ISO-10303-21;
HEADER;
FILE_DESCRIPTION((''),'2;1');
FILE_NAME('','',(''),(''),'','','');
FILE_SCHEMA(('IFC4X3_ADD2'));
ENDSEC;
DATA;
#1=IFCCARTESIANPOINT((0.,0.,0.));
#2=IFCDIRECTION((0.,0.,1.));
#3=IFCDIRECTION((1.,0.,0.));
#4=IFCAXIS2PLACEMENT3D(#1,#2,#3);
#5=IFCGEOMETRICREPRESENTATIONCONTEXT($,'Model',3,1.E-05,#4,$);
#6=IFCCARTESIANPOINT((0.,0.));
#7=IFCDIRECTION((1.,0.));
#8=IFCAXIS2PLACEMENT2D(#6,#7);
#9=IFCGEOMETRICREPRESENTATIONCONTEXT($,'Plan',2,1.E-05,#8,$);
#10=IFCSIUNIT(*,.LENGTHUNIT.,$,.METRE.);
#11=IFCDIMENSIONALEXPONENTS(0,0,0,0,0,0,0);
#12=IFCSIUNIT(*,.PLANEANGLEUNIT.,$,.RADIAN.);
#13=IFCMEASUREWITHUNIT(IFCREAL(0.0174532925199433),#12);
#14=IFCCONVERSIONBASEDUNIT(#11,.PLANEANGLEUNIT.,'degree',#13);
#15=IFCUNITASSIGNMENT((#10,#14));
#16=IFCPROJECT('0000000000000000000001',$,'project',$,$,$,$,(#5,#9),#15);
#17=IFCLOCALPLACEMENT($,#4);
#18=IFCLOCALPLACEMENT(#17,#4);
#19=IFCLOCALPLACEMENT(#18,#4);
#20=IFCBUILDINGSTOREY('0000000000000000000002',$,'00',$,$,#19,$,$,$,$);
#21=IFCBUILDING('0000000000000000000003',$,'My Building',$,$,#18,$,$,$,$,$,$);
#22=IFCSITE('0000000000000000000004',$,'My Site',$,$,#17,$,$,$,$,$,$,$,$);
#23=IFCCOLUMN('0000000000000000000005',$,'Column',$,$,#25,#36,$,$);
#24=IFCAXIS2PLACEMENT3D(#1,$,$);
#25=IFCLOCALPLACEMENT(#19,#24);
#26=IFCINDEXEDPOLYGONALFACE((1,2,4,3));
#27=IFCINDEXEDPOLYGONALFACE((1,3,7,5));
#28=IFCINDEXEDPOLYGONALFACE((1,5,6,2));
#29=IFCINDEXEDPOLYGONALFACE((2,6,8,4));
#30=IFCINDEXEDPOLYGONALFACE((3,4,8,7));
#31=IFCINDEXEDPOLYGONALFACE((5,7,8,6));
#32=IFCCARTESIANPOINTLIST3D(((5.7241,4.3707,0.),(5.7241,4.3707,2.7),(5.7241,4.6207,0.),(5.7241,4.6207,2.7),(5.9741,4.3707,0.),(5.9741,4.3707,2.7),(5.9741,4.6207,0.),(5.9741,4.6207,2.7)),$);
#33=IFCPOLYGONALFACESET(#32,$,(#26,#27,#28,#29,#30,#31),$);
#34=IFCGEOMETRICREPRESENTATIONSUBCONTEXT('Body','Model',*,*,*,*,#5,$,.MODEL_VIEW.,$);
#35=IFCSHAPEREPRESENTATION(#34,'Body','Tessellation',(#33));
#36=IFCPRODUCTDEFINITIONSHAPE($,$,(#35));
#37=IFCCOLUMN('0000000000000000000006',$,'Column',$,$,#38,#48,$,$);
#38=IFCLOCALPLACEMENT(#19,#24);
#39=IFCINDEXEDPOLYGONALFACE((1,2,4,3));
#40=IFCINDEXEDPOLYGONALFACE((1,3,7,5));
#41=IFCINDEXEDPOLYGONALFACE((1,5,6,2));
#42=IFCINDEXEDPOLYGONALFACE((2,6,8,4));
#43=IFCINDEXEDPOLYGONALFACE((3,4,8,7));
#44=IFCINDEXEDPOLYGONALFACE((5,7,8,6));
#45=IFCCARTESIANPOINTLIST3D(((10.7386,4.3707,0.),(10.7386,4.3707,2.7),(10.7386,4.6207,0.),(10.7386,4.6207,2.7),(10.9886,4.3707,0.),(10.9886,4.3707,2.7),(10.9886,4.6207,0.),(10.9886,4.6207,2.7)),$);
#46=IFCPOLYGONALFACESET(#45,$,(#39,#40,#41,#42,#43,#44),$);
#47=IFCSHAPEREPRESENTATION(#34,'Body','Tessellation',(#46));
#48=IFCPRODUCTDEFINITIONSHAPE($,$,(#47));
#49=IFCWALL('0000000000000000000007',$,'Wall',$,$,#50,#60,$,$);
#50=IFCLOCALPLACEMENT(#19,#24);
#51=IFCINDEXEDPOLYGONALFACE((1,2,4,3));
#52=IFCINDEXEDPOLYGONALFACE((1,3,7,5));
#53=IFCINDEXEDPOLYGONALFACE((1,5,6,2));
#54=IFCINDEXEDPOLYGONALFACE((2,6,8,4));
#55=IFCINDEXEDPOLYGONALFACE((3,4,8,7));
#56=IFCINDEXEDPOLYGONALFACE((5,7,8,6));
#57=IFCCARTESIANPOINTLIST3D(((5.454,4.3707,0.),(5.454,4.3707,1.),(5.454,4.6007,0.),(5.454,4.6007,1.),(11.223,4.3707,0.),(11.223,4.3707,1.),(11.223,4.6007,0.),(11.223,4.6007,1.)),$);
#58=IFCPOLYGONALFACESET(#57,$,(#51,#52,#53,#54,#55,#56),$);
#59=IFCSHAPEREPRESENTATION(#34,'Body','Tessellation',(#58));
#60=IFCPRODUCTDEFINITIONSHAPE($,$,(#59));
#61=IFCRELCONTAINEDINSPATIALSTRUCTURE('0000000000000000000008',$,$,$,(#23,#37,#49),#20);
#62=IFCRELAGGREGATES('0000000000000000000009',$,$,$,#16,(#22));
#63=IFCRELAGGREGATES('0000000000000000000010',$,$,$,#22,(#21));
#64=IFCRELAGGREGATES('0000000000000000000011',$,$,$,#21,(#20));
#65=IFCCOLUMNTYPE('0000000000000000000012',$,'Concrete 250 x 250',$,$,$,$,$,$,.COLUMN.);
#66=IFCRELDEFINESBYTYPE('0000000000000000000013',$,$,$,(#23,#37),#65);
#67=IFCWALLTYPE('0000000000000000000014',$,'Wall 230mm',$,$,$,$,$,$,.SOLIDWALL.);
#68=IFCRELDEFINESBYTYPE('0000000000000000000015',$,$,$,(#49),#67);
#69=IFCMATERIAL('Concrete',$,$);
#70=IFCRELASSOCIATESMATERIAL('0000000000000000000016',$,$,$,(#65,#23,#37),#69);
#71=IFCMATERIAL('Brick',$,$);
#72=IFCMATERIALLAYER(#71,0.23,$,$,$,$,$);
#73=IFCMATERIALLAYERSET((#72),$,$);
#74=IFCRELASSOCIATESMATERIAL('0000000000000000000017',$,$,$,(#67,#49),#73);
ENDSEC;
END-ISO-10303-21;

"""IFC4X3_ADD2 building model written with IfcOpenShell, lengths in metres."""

from ifc_helpers import new_model, entity, si_unit, converted_unit, frame, origin_with_axes, origin_2d_with_axis, place, context, subcontext, project, spatial, indexed_curve, rectangle, outline, extrude, material, layer, layer_set, layer_usage, material_profile, profile_set, profile_usage, type_object, element, save


model = new_model("IFC4X3_ADD2")

# Units and contexts
model_context = context("Model", 3, precision=1e-05, world=origin_with_axes())
plan_context = context("Plan", 2, precision=1e-05, world=origin_2d_with_axis())
body_context = subcontext(model_context, "Body", "Model", "MODEL_VIEW")
ifc_project = project(units=[si_unit("LENGTHUNIT", "METRE"), converted_unit("PLANEANGLEUNIT", "degree", entity("IfcReal", 0.0174532925199433), si_unit("PLANEANGLEUNIT", "RADIAN"), dimensions=[0, 0, 0, 0, 0, 0, 0])], contexts=[model_context, plan_context])

# Site, building, storey
site_placement = place(None, origin_with_axes())
site = spatial("IfcSite", under=ifc_project, at=site_placement, Name="My Site")
building_placement = place(site_placement, origin_with_axes())
building = spatial("IfcBuilding", under=site, at=building_placement, Name="My Building")
storey_placement = place(building_placement, origin_with_axes())
storey = spatial("IfcBuildingStorey", under=building, at=storey_placement, Name="00")

# Columns
ifc_material_1 = material(Name="Concrete")
ifc_material_profile = material_profile(ifc_material_1, rectangle(XDim=0.25, YDim=0.25))
ifc_profile_set = profile_set([ifc_material_profile])
column_type = type_object("IfcColumnType", Name="Concrete 250 x 250", PredefinedType="COLUMN", material=ifc_profile_set)
ifc_profile_usage_1 = profile_usage(ifc_profile_set, cardinal=5)
column_1_placement = place(storey_placement, frame((5.8491, 4.4957, 0.0), z_axis=(0.0, 0.0, 1.0), x_axis=(1.0, 0.0, 0.0)))
element("IfcColumn", 1, at=column_1_placement, inside=storey, type_object=column_type, material=ifc_profile_usage_1, Name="Column", context=body_context, shape_type="SweptSolid", body=[
    extrude(rectangle(XDim=0.25, YDim=0.25), origin_with_axes(), (0.0, 0.0, 1.0), 2.7),
])
ifc_profile_usage_2 = profile_usage(ifc_profile_set, cardinal=5)
column_2_placement = place(storey_placement, frame((10.8636, 4.4957, 0.0), z_axis=(0.0, 0.0, 1.0), x_axis=(1.0, 0.0, 0.0)))
element("IfcColumn", 2, at=column_2_placement, inside=storey, type_object=column_type, material=ifc_profile_usage_2, Name="Column", context=body_context, shape_type="SweptSolid", body=[
    extrude(rectangle(XDim=0.25, YDim=0.25), origin_with_axes(), (0.0, 0.0, 1.0), 2.7),
])

# Wall
ifc_material_2 = material(Name="Brick")
ifc_layer_1 = layer(ifc_material_2, 0.23)
ifc_layer_set_1 = layer_set([ifc_layer_1])
ifc_layer_usage_1 = layer_usage(ifc_layer_set_1, "AXIS2", "POSITIVE", 0.0)
wall_type_1 = type_object("IfcWallType", Name="Wall 230mm", PredefinedType="SOLIDWALL", material=ifc_layer_set_1)
wall_1_placement = place(storey_placement, frame((5.454, 4.3707, 0.0), z_axis=(0.0, 0.0, 1.0), x_axis=(1.0, 0.0, 0.0)))
element("IfcWall", 3, at=wall_1_placement, inside=storey, type_object=wall_type_1, material=ifc_layer_usage_1, Name="Wall", context=body_context, shape_type="SweptSolid", body=[
    extrude(outline(indexed_curve([(0.0, 0.0), (0.0, 0.23), (5.769, 0.23), (5.769, 0.0), (0.0, 0.0)], self_intersect=False)), origin_with_axes(), (0.0, 0.0, 1.0), 1.0),
])

save(model, "model.ifc")
